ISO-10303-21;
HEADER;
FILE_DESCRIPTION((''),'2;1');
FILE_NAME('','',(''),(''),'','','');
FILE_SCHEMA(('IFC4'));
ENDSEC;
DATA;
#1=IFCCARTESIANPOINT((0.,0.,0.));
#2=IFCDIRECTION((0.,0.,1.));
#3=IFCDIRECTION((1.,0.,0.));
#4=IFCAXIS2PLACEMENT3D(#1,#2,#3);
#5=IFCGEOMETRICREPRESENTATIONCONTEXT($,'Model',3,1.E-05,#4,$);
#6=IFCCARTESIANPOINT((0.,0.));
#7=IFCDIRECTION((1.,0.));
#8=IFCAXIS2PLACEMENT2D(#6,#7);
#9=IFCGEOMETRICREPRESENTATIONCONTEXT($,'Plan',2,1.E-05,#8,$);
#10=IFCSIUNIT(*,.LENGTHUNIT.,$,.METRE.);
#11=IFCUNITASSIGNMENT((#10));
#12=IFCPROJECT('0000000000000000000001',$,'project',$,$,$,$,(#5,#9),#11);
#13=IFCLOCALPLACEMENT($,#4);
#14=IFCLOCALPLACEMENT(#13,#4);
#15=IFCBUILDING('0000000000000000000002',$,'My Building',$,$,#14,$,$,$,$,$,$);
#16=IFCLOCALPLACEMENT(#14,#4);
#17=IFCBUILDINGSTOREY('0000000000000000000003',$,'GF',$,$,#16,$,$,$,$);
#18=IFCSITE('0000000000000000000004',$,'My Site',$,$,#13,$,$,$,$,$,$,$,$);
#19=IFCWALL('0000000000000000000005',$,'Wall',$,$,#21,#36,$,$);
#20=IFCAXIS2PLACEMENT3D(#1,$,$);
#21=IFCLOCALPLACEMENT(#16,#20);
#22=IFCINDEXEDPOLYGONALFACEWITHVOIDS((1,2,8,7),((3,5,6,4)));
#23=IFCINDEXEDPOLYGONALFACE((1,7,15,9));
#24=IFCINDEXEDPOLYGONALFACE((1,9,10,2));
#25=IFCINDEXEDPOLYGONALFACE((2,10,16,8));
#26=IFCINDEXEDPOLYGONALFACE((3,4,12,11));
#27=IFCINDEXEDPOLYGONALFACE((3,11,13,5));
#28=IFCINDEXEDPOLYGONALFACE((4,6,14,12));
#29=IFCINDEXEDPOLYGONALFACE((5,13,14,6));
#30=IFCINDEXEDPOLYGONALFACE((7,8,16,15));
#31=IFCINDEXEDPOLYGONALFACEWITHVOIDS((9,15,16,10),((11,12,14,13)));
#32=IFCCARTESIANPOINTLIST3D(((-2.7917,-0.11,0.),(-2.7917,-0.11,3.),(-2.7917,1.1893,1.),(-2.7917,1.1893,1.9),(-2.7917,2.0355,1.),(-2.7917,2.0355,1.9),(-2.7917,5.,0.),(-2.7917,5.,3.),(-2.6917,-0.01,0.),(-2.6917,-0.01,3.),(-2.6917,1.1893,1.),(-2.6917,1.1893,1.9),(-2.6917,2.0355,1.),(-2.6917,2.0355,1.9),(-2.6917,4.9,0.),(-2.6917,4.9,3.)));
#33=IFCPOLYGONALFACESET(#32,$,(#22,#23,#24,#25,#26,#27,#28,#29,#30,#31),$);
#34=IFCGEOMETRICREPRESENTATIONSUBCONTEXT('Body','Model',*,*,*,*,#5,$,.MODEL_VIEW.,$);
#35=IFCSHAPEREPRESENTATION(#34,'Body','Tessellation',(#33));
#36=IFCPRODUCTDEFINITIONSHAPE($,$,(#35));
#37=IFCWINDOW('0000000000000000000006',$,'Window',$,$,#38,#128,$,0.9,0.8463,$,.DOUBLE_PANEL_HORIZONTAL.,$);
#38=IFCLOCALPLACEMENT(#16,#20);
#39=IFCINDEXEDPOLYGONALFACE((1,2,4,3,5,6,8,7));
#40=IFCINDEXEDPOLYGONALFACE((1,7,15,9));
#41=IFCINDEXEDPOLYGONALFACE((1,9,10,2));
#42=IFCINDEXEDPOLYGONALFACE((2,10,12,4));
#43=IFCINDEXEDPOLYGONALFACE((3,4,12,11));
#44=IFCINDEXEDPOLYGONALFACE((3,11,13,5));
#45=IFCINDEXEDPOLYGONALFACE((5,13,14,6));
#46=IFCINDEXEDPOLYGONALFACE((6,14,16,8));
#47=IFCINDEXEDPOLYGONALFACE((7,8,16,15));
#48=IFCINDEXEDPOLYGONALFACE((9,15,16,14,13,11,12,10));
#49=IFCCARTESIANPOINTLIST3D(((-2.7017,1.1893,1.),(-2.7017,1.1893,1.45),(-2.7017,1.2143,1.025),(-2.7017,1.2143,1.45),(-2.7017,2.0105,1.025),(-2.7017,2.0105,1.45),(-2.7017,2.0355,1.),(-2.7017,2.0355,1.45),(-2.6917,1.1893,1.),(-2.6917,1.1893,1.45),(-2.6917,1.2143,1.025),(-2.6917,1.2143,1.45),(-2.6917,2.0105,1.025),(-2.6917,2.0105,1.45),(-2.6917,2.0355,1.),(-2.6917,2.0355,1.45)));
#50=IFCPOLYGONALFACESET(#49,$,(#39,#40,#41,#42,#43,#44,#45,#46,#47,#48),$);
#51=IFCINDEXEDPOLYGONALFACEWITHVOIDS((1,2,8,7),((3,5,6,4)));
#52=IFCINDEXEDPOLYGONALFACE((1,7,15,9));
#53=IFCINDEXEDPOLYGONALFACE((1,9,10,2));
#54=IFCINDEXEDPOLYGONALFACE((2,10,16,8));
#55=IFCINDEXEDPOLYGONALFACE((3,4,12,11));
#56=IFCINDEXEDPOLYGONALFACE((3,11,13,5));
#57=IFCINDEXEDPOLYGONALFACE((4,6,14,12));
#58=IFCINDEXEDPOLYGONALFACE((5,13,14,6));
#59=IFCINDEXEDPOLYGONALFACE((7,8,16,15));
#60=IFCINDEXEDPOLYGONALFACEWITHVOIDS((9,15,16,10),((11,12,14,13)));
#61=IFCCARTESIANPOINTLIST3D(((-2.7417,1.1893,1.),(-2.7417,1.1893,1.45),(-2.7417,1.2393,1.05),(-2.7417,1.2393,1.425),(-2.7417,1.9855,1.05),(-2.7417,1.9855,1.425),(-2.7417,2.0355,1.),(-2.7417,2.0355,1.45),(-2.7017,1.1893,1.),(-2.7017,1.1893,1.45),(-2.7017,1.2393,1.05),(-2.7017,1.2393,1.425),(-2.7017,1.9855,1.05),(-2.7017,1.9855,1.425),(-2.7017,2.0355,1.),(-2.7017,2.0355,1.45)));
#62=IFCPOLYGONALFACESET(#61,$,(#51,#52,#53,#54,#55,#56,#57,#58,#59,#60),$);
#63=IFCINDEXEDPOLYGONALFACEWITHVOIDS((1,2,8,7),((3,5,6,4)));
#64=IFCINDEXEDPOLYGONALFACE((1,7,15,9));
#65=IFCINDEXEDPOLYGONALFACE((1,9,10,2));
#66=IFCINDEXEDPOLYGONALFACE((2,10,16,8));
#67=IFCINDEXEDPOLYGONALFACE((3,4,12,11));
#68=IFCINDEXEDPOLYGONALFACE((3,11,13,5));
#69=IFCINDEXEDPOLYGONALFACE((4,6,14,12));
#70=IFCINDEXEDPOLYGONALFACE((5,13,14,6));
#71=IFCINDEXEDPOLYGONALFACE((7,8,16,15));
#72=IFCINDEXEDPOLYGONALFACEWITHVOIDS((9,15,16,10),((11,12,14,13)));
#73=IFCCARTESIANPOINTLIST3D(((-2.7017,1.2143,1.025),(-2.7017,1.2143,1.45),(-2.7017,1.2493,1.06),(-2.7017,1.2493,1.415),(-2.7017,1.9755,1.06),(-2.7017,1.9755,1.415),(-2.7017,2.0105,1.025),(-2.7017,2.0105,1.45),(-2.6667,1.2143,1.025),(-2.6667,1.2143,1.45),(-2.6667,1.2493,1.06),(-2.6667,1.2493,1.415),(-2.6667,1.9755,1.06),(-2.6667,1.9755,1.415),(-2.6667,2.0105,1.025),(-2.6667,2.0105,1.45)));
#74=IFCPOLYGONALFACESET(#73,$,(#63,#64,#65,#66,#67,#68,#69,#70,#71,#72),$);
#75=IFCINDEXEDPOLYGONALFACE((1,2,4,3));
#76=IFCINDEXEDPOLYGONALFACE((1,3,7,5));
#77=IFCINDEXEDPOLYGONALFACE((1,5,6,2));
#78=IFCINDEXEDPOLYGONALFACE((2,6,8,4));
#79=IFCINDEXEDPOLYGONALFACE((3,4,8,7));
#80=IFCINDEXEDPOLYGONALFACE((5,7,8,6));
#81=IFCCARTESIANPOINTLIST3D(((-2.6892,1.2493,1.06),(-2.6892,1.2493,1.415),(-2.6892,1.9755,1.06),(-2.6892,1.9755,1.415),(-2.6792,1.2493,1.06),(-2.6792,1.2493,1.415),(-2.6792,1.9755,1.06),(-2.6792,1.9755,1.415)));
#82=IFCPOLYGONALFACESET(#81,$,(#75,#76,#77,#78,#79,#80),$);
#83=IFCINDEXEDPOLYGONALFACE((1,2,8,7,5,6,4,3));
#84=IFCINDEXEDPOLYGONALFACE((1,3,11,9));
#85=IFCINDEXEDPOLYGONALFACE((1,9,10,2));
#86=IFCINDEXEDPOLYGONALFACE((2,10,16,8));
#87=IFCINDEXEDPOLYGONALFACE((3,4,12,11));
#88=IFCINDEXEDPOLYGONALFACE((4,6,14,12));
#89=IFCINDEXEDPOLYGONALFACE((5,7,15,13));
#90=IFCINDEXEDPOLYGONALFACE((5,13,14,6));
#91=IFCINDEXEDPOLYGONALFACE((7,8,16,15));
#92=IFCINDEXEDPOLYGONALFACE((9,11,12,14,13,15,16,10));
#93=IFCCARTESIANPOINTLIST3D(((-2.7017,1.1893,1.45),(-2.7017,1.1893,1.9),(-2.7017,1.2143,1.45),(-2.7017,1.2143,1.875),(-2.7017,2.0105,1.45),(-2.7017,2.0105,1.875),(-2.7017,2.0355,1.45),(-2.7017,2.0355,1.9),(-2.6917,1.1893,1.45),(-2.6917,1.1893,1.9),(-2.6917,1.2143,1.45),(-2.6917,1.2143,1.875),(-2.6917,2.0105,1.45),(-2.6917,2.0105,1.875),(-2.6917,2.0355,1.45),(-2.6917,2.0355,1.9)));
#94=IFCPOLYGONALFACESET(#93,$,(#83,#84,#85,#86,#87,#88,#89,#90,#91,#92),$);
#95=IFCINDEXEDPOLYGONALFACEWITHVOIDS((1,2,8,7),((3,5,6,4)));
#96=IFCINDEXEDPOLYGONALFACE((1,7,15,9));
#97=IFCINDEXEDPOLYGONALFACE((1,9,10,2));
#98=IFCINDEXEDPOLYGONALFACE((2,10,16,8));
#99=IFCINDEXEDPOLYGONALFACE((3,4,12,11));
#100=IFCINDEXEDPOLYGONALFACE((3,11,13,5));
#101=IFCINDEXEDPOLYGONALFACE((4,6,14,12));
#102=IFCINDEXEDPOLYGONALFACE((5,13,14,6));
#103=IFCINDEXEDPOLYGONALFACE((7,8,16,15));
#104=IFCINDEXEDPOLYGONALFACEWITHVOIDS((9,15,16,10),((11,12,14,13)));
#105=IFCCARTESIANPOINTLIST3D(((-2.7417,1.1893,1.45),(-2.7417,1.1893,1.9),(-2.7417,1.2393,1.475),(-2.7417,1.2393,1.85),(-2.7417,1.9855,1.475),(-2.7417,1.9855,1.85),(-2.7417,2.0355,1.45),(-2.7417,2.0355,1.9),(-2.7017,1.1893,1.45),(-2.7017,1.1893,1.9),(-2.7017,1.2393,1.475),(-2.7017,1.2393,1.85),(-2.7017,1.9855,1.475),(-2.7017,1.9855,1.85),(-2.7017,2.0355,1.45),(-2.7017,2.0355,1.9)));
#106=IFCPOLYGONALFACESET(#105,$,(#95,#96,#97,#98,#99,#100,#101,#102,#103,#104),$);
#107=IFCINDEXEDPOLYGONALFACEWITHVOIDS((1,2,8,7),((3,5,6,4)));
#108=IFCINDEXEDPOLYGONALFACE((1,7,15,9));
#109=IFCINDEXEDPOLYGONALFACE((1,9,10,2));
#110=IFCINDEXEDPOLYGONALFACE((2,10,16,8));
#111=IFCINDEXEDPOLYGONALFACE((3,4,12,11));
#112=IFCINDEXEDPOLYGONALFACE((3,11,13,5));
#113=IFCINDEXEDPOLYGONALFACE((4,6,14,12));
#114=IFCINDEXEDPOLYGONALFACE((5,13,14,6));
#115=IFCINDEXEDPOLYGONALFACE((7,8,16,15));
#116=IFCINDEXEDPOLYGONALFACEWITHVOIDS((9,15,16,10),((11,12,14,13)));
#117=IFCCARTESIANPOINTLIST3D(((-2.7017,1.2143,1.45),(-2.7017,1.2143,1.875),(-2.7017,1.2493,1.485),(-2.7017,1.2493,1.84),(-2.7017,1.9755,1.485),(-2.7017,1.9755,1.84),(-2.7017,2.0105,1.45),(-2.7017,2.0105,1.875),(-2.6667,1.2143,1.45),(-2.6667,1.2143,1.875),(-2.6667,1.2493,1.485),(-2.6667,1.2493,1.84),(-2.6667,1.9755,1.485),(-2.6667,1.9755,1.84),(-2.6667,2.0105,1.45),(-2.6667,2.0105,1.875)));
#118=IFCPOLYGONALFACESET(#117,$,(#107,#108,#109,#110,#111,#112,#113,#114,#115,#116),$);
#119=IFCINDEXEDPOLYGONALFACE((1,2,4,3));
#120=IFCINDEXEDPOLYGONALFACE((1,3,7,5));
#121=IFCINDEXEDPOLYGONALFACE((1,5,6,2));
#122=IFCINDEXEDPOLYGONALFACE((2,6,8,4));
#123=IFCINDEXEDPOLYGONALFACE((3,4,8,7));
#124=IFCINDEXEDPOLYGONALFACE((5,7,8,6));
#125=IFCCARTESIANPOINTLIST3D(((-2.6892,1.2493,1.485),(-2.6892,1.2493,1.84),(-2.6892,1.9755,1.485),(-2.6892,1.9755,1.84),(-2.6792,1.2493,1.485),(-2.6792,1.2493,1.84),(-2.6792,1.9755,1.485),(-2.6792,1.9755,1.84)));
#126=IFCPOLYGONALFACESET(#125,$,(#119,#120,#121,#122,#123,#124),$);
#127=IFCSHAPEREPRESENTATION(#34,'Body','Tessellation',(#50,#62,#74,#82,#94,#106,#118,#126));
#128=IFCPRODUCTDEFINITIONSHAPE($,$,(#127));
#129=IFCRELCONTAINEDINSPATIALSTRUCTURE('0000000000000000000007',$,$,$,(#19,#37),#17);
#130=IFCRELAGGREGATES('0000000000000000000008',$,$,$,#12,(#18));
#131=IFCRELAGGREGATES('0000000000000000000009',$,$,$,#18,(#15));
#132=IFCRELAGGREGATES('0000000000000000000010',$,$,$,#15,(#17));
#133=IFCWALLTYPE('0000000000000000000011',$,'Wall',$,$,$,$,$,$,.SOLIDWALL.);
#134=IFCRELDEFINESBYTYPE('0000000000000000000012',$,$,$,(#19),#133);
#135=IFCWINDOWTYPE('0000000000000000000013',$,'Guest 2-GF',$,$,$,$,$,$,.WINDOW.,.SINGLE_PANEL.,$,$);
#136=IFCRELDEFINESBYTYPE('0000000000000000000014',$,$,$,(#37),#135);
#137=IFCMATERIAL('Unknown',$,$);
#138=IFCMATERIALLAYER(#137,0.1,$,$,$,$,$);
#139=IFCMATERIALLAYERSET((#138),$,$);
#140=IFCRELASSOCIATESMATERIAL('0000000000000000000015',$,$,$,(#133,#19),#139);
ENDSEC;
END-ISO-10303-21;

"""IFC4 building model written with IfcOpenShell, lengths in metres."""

from ifc_helpers import new_model, entity, si_unit, frame, origin_with_axes, origin_2d_with_axis, place, context, subcontext, project, spatial, line, indexed_curve, outline, extrude, shape, source, transform, mapped, material, layer, layer_set, layer_usage, type_object, type_shapes, element, fill, save


model = new_model("IFC4")

# Units and contexts
model_context_1 = context("Model", 3, precision=1e-05, world=origin_with_axes())
plan_context = context("Plan", 2, precision=1e-05, world=origin_2d_with_axis())
body_context_1 = subcontext(model_context_1, "Body", "Model", "MODEL_VIEW")
body_context_2 = subcontext(plan_context, "Body", "Plan", "PLAN_VIEW")
ifc_project = project(units=[si_unit("LENGTHUNIT", "METRE")], contexts=[model_context_1, plan_context])

# Site, building, storey
site_placement = place(None, origin_with_axes())
site = spatial("IfcSite", under=ifc_project, at=site_placement, Name="My Site")
building_placement = place(site_placement, origin_with_axes())
building = spatial("IfcBuilding", under=site, at=building_placement, Name="My Building")
storey_placement = place(building_placement, origin_with_axes())
storey = spatial("IfcBuildingStorey", under=building, at=storey_placement, Name="GF")

# Shared definitions
ifc_material_1 = material(Name="Unknown")

# Shared definitions
ifc_layer_1 = layer(ifc_material_1, 0.1)
ifc_layer_set_1 = layer_set([ifc_layer_1])
wall_type = type_object("IfcWallType", Name="Wall", PredefinedType="SOLIDWALL", material=ifc_layer_set_1)

# Wall, opening, window
ifc_layer_usage_1 = layer_usage(ifc_layer_set_1, "AXIS2", "POSITIVE", 0.0)
wall_1_placement = place(storey_placement, frame((-2.7917, 5.0, 0.0), z_axis=(0.0, 0.0, 1.0), x_axis=(0.0, -1.0, 0.0)))
wall_1 = element("IfcWall", 1, at=wall_1_placement, inside=storey, type_object=wall_type, material=ifc_layer_usage_1, Name="Wall", context=body_context_1, shape_type="SweptSolid", body=[
    extrude(outline(indexed_curve([(0.0, 0.0), (0.1, 0.1), (5.01, 0.1), (5.11, 0.0)], segments=[line(1, 2, 3, 4, 1)])), origin_with_axes(), (0.0, 0.0, 1.0), 3.0),
])
shared_shape_1 = source(origin_with_axes(), body_context_1, "Body", "SweptSolid", [
    extrude(outline(indexed_curve([(0.0, 0.0), (0.8463, 0.0), (0.8463, 0.9), (0.0, 0.9)], segments=[line(1, 2, 3, 4, 1)])), frame((0.0, -0.6, 0.0), z_axis=(0.0, -1.0, 0.0), x_axis=(1.0, 0.0, 0.0)), (0.0, 0.0, -1.0), 1.2),
])
opening_1_placement = place(wall_1_placement, frame((2.9644, 0.0, 1.0), z_axis=(0.0, 0.0, 1.0), x_axis=(1.0, 0.0, 0.0)))
opening_1 = element("IfcOpeningElement", 2, at=opening_1_placement, cuts=wall_1, PredefinedType="OPENING", context=body_context_1, shape_type="MappedRepresentation", body=[
    mapped(shared_shape_1, transform((0.0, 0.0, 0.0), x_axis=(1.0, 0.0, 0.0), y_axis=(0.0, 1.0, 0.0), z_axis=(0.0, 0.0, 1.0), scale=1.0)),
])
window_type_1 = type_object("IfcWindowType", Name="Guest 2-GF", PartitioningType="SINGLE_PANEL", PredefinedType="WINDOW")
shared_shape_2 = source(origin_with_axes(), body_context_1, "Body", "SweptSolid", [
    extrude(outline(indexed_curve([(0.8463, 0.45), (0.8463, 0.0), (0.0, 0.0), (0.0, 0.45), (0.025, 0.45), (0.025, 0.025), (0.8213, 0.025), (0.8213, 0.45)], segments=[line(1, 2, 3, 4, 5, 6, 7, 8, 1)])), frame((0.0, 0.09, 0.0), z_axis=(0.0, -1.0, 0.0), x_axis=(1.0, 0.0, 0.0)), (0.0, 0.0, -1.0), 0.01),
    extrude(outline(indexed_curve([(0.0, 0.0), (0.8463, 0.0), (0.8463, 0.45), (0.0, 0.45)], segments=[line(1, 2, 3, 4, 1)]), holes=[indexed_curve([(0.05, 0.05), (0.7963, 0.05), (0.7963, 0.425), (0.05, 0.425)], segments=[line(1, 2, 3, 4, 1)])]), frame((0.0, 0.05, 0.0), z_axis=(0.0, -1.0, 0.0), x_axis=(1.0, 0.0, 0.0)), (0.0, 0.0, -1.0), 0.04),
    extrude(outline(indexed_curve([(0.0, 0.0), (0.7963, 0.0), (0.7963, 0.425), (0.0, 0.425)], segments=[line(1, 2, 3, 4, 1)]), holes=[indexed_curve([(0.035, 0.035), (0.7613, 0.035), (0.7613, 0.39), (0.035, 0.39)], segments=[line(1, 2, 3, 4, 1)])]), frame((0.025, 0.09, 0.025), z_axis=(0.0, -1.0, 0.0), x_axis=(1.0, 0.0, 0.0)), (0.0, 0.0, -1.0), 0.035),
    extrude(outline(indexed_curve([(0.035, 0.035), (0.7613, 0.035), (0.7613, 0.39), (0.035, 0.39)], segments=[line(1, 2, 3, 4, 1)])), frame((0.025, 0.1025, 0.025), z_axis=(0.0, -1.0, 0.0), x_axis=(1.0, 0.0, 0.0)), (0.0, 0.0, -1.0), 0.01),
    extrude(outline(indexed_curve([(0.0, 0.0), (0.0, 0.45), (0.8463, 0.45), (0.8463, 0.0), (0.8213, 0.0), (0.8213, 0.425), (0.025, 0.425), (0.025, 0.0)], segments=[line(1, 2, 3, 4, 5, 6, 7, 8, 1)])), frame((0.0, 0.09, 0.45), z_axis=(0.0, -1.0, 0.0), x_axis=(1.0, 0.0, 0.0)), (0.0, 0.0, -1.0), 0.01),
    extrude(outline(indexed_curve([(0.0, 0.0), (0.8463, 0.0), (0.8463, 0.45), (0.0, 0.45)], segments=[line(1, 2, 3, 4, 1)]), holes=[indexed_curve([(0.05, 0.025), (0.7963, 0.025), (0.7963, 0.4), (0.05, 0.4)], segments=[line(1, 2, 3, 4, 1)])]), frame((0.0, 0.05, 0.45), z_axis=(0.0, -1.0, 0.0), x_axis=(1.0, 0.0, 0.0)), (0.0, 0.0, -1.0), 0.04),
    extrude(outline(indexed_curve([(0.0, 0.0), (0.7963, 0.0), (0.7963, 0.425), (0.0, 0.425)], segments=[line(1, 2, 3, 4, 1)]), holes=[indexed_curve([(0.035, 0.035), (0.7613, 0.035), (0.7613, 0.39), (0.035, 0.39)], segments=[line(1, 2, 3, 4, 1)])]), frame((0.025, 0.09, 0.45), z_axis=(0.0, -1.0, 0.0), x_axis=(1.0, 0.0, 0.0)), (0.0, 0.0, -1.0), 0.035),
    extrude(outline(indexed_curve([(0.035, 0.035), (0.7613, 0.035), (0.7613, 0.39), (0.035, 0.39)], segments=[line(1, 2, 3, 4, 1)])), frame((0.025, 0.1025, 0.45), z_axis=(0.0, -1.0, 0.0), x_axis=(1.0, 0.0, 0.0)), (0.0, 0.0, -1.0), 0.01),
])
shared_shape_3 = source(origin_with_axes(), body_context_2, "Body", "Curve2D", [
    entity("IfcIndexedPolyCurve", entity("IfcCartesianPointList2D", [[0.05, 0.05], [0.7963, 0.05]])),
    entity("IfcIndexedPolyCurve", entity("IfcCartesianPointList2D", [[0.0, 0.1], [0.025, 0.1], [0.025, 0.09], [0.05, 0.09], [0.05, 0.05], [0.0, 0.05]]), [entity("IfcLineIndex", [1, 2, 3, 4, 5, 6, 1])]),
    entity("IfcIndexedPolyCurve", entity("IfcCartesianPointList2D", [[0.8463, 0.1], [0.8213, 0.1], [0.8213, 0.09], [0.7963, 0.09], [0.7963, 0.05], [0.8463, 0.05]]), [entity("IfcLineIndex", [1, 2, 3, 4, 5, 6, 1])]),
    entity("IfcIndexedPolyCurve", entity("IfcCartesianPointList2D", [[0.025, 0.09], [0.06, 0.09], [0.06, 0.125], [0.025, 0.125]]), [entity("IfcLineIndex", [1, 2, 3, 4, 1])]),
    entity("IfcIndexedPolyCurve", entity("IfcCartesianPointList2D", [[0.8213, 0.09], [0.7863, 0.09], [0.7863, 0.125], [0.8213, 0.125]]), [entity("IfcLineIndex", [1, 2, 3, 4, 1])]),
    entity("IfcIndexedPolyCurve", entity("IfcCartesianPointList2D", [[0.06, 0.09], [0.7863, 0.09]])),
    entity("IfcIndexedPolyCurve", entity("IfcCartesianPointList2D", [[0.06, 0.125], [0.7863, 0.125]])),
    entity("IfcIndexedPolyCurve", entity("IfcCartesianPointList2D", [[0.06, 0.1075], [0.7863, 0.1075]])),
])
type_shapes(window_type_1, [shared_shape_2, shared_shape_3])
window_1_placement = place(opening_1_placement, frame((0.0, 0.0, 0.0), z_axis=(0.0, 0.0, 1.0), x_axis=(1.0, 0.0, 0.0)))
window_1 = element("IfcWindow", 3, at=window_1_placement, inside=storey, type_object=window_type_1, Name="Window", OverallHeight=0.9, OverallWidth=0.8463, PartitioningType="DOUBLE_PANEL_HORIZONTAL", shapes=[
    shape(body_context_1, "Body", "MappedRepresentation", [mapped(shared_shape_2, transform((0.0, 0.0, 0.0), x_axis=(1.0, 0.0, 0.0), y_axis=(0.0, 1.0, 0.0), z_axis=(0.0, 0.0, 1.0), scale=1.0))]),
    shape(body_context_2, "Body", "MappedRepresentation", [mapped(shared_shape_3, transform((0.0, 0.0, 0.0), x_axis=(1.0, 0.0, 0.0), y_axis=(0.0, 1.0, 0.0), z_axis=(0.0, 0.0, 1.0), scale=1.0))]),
])
fill(opening_1, window_1)

save(model, "model.ifc")
